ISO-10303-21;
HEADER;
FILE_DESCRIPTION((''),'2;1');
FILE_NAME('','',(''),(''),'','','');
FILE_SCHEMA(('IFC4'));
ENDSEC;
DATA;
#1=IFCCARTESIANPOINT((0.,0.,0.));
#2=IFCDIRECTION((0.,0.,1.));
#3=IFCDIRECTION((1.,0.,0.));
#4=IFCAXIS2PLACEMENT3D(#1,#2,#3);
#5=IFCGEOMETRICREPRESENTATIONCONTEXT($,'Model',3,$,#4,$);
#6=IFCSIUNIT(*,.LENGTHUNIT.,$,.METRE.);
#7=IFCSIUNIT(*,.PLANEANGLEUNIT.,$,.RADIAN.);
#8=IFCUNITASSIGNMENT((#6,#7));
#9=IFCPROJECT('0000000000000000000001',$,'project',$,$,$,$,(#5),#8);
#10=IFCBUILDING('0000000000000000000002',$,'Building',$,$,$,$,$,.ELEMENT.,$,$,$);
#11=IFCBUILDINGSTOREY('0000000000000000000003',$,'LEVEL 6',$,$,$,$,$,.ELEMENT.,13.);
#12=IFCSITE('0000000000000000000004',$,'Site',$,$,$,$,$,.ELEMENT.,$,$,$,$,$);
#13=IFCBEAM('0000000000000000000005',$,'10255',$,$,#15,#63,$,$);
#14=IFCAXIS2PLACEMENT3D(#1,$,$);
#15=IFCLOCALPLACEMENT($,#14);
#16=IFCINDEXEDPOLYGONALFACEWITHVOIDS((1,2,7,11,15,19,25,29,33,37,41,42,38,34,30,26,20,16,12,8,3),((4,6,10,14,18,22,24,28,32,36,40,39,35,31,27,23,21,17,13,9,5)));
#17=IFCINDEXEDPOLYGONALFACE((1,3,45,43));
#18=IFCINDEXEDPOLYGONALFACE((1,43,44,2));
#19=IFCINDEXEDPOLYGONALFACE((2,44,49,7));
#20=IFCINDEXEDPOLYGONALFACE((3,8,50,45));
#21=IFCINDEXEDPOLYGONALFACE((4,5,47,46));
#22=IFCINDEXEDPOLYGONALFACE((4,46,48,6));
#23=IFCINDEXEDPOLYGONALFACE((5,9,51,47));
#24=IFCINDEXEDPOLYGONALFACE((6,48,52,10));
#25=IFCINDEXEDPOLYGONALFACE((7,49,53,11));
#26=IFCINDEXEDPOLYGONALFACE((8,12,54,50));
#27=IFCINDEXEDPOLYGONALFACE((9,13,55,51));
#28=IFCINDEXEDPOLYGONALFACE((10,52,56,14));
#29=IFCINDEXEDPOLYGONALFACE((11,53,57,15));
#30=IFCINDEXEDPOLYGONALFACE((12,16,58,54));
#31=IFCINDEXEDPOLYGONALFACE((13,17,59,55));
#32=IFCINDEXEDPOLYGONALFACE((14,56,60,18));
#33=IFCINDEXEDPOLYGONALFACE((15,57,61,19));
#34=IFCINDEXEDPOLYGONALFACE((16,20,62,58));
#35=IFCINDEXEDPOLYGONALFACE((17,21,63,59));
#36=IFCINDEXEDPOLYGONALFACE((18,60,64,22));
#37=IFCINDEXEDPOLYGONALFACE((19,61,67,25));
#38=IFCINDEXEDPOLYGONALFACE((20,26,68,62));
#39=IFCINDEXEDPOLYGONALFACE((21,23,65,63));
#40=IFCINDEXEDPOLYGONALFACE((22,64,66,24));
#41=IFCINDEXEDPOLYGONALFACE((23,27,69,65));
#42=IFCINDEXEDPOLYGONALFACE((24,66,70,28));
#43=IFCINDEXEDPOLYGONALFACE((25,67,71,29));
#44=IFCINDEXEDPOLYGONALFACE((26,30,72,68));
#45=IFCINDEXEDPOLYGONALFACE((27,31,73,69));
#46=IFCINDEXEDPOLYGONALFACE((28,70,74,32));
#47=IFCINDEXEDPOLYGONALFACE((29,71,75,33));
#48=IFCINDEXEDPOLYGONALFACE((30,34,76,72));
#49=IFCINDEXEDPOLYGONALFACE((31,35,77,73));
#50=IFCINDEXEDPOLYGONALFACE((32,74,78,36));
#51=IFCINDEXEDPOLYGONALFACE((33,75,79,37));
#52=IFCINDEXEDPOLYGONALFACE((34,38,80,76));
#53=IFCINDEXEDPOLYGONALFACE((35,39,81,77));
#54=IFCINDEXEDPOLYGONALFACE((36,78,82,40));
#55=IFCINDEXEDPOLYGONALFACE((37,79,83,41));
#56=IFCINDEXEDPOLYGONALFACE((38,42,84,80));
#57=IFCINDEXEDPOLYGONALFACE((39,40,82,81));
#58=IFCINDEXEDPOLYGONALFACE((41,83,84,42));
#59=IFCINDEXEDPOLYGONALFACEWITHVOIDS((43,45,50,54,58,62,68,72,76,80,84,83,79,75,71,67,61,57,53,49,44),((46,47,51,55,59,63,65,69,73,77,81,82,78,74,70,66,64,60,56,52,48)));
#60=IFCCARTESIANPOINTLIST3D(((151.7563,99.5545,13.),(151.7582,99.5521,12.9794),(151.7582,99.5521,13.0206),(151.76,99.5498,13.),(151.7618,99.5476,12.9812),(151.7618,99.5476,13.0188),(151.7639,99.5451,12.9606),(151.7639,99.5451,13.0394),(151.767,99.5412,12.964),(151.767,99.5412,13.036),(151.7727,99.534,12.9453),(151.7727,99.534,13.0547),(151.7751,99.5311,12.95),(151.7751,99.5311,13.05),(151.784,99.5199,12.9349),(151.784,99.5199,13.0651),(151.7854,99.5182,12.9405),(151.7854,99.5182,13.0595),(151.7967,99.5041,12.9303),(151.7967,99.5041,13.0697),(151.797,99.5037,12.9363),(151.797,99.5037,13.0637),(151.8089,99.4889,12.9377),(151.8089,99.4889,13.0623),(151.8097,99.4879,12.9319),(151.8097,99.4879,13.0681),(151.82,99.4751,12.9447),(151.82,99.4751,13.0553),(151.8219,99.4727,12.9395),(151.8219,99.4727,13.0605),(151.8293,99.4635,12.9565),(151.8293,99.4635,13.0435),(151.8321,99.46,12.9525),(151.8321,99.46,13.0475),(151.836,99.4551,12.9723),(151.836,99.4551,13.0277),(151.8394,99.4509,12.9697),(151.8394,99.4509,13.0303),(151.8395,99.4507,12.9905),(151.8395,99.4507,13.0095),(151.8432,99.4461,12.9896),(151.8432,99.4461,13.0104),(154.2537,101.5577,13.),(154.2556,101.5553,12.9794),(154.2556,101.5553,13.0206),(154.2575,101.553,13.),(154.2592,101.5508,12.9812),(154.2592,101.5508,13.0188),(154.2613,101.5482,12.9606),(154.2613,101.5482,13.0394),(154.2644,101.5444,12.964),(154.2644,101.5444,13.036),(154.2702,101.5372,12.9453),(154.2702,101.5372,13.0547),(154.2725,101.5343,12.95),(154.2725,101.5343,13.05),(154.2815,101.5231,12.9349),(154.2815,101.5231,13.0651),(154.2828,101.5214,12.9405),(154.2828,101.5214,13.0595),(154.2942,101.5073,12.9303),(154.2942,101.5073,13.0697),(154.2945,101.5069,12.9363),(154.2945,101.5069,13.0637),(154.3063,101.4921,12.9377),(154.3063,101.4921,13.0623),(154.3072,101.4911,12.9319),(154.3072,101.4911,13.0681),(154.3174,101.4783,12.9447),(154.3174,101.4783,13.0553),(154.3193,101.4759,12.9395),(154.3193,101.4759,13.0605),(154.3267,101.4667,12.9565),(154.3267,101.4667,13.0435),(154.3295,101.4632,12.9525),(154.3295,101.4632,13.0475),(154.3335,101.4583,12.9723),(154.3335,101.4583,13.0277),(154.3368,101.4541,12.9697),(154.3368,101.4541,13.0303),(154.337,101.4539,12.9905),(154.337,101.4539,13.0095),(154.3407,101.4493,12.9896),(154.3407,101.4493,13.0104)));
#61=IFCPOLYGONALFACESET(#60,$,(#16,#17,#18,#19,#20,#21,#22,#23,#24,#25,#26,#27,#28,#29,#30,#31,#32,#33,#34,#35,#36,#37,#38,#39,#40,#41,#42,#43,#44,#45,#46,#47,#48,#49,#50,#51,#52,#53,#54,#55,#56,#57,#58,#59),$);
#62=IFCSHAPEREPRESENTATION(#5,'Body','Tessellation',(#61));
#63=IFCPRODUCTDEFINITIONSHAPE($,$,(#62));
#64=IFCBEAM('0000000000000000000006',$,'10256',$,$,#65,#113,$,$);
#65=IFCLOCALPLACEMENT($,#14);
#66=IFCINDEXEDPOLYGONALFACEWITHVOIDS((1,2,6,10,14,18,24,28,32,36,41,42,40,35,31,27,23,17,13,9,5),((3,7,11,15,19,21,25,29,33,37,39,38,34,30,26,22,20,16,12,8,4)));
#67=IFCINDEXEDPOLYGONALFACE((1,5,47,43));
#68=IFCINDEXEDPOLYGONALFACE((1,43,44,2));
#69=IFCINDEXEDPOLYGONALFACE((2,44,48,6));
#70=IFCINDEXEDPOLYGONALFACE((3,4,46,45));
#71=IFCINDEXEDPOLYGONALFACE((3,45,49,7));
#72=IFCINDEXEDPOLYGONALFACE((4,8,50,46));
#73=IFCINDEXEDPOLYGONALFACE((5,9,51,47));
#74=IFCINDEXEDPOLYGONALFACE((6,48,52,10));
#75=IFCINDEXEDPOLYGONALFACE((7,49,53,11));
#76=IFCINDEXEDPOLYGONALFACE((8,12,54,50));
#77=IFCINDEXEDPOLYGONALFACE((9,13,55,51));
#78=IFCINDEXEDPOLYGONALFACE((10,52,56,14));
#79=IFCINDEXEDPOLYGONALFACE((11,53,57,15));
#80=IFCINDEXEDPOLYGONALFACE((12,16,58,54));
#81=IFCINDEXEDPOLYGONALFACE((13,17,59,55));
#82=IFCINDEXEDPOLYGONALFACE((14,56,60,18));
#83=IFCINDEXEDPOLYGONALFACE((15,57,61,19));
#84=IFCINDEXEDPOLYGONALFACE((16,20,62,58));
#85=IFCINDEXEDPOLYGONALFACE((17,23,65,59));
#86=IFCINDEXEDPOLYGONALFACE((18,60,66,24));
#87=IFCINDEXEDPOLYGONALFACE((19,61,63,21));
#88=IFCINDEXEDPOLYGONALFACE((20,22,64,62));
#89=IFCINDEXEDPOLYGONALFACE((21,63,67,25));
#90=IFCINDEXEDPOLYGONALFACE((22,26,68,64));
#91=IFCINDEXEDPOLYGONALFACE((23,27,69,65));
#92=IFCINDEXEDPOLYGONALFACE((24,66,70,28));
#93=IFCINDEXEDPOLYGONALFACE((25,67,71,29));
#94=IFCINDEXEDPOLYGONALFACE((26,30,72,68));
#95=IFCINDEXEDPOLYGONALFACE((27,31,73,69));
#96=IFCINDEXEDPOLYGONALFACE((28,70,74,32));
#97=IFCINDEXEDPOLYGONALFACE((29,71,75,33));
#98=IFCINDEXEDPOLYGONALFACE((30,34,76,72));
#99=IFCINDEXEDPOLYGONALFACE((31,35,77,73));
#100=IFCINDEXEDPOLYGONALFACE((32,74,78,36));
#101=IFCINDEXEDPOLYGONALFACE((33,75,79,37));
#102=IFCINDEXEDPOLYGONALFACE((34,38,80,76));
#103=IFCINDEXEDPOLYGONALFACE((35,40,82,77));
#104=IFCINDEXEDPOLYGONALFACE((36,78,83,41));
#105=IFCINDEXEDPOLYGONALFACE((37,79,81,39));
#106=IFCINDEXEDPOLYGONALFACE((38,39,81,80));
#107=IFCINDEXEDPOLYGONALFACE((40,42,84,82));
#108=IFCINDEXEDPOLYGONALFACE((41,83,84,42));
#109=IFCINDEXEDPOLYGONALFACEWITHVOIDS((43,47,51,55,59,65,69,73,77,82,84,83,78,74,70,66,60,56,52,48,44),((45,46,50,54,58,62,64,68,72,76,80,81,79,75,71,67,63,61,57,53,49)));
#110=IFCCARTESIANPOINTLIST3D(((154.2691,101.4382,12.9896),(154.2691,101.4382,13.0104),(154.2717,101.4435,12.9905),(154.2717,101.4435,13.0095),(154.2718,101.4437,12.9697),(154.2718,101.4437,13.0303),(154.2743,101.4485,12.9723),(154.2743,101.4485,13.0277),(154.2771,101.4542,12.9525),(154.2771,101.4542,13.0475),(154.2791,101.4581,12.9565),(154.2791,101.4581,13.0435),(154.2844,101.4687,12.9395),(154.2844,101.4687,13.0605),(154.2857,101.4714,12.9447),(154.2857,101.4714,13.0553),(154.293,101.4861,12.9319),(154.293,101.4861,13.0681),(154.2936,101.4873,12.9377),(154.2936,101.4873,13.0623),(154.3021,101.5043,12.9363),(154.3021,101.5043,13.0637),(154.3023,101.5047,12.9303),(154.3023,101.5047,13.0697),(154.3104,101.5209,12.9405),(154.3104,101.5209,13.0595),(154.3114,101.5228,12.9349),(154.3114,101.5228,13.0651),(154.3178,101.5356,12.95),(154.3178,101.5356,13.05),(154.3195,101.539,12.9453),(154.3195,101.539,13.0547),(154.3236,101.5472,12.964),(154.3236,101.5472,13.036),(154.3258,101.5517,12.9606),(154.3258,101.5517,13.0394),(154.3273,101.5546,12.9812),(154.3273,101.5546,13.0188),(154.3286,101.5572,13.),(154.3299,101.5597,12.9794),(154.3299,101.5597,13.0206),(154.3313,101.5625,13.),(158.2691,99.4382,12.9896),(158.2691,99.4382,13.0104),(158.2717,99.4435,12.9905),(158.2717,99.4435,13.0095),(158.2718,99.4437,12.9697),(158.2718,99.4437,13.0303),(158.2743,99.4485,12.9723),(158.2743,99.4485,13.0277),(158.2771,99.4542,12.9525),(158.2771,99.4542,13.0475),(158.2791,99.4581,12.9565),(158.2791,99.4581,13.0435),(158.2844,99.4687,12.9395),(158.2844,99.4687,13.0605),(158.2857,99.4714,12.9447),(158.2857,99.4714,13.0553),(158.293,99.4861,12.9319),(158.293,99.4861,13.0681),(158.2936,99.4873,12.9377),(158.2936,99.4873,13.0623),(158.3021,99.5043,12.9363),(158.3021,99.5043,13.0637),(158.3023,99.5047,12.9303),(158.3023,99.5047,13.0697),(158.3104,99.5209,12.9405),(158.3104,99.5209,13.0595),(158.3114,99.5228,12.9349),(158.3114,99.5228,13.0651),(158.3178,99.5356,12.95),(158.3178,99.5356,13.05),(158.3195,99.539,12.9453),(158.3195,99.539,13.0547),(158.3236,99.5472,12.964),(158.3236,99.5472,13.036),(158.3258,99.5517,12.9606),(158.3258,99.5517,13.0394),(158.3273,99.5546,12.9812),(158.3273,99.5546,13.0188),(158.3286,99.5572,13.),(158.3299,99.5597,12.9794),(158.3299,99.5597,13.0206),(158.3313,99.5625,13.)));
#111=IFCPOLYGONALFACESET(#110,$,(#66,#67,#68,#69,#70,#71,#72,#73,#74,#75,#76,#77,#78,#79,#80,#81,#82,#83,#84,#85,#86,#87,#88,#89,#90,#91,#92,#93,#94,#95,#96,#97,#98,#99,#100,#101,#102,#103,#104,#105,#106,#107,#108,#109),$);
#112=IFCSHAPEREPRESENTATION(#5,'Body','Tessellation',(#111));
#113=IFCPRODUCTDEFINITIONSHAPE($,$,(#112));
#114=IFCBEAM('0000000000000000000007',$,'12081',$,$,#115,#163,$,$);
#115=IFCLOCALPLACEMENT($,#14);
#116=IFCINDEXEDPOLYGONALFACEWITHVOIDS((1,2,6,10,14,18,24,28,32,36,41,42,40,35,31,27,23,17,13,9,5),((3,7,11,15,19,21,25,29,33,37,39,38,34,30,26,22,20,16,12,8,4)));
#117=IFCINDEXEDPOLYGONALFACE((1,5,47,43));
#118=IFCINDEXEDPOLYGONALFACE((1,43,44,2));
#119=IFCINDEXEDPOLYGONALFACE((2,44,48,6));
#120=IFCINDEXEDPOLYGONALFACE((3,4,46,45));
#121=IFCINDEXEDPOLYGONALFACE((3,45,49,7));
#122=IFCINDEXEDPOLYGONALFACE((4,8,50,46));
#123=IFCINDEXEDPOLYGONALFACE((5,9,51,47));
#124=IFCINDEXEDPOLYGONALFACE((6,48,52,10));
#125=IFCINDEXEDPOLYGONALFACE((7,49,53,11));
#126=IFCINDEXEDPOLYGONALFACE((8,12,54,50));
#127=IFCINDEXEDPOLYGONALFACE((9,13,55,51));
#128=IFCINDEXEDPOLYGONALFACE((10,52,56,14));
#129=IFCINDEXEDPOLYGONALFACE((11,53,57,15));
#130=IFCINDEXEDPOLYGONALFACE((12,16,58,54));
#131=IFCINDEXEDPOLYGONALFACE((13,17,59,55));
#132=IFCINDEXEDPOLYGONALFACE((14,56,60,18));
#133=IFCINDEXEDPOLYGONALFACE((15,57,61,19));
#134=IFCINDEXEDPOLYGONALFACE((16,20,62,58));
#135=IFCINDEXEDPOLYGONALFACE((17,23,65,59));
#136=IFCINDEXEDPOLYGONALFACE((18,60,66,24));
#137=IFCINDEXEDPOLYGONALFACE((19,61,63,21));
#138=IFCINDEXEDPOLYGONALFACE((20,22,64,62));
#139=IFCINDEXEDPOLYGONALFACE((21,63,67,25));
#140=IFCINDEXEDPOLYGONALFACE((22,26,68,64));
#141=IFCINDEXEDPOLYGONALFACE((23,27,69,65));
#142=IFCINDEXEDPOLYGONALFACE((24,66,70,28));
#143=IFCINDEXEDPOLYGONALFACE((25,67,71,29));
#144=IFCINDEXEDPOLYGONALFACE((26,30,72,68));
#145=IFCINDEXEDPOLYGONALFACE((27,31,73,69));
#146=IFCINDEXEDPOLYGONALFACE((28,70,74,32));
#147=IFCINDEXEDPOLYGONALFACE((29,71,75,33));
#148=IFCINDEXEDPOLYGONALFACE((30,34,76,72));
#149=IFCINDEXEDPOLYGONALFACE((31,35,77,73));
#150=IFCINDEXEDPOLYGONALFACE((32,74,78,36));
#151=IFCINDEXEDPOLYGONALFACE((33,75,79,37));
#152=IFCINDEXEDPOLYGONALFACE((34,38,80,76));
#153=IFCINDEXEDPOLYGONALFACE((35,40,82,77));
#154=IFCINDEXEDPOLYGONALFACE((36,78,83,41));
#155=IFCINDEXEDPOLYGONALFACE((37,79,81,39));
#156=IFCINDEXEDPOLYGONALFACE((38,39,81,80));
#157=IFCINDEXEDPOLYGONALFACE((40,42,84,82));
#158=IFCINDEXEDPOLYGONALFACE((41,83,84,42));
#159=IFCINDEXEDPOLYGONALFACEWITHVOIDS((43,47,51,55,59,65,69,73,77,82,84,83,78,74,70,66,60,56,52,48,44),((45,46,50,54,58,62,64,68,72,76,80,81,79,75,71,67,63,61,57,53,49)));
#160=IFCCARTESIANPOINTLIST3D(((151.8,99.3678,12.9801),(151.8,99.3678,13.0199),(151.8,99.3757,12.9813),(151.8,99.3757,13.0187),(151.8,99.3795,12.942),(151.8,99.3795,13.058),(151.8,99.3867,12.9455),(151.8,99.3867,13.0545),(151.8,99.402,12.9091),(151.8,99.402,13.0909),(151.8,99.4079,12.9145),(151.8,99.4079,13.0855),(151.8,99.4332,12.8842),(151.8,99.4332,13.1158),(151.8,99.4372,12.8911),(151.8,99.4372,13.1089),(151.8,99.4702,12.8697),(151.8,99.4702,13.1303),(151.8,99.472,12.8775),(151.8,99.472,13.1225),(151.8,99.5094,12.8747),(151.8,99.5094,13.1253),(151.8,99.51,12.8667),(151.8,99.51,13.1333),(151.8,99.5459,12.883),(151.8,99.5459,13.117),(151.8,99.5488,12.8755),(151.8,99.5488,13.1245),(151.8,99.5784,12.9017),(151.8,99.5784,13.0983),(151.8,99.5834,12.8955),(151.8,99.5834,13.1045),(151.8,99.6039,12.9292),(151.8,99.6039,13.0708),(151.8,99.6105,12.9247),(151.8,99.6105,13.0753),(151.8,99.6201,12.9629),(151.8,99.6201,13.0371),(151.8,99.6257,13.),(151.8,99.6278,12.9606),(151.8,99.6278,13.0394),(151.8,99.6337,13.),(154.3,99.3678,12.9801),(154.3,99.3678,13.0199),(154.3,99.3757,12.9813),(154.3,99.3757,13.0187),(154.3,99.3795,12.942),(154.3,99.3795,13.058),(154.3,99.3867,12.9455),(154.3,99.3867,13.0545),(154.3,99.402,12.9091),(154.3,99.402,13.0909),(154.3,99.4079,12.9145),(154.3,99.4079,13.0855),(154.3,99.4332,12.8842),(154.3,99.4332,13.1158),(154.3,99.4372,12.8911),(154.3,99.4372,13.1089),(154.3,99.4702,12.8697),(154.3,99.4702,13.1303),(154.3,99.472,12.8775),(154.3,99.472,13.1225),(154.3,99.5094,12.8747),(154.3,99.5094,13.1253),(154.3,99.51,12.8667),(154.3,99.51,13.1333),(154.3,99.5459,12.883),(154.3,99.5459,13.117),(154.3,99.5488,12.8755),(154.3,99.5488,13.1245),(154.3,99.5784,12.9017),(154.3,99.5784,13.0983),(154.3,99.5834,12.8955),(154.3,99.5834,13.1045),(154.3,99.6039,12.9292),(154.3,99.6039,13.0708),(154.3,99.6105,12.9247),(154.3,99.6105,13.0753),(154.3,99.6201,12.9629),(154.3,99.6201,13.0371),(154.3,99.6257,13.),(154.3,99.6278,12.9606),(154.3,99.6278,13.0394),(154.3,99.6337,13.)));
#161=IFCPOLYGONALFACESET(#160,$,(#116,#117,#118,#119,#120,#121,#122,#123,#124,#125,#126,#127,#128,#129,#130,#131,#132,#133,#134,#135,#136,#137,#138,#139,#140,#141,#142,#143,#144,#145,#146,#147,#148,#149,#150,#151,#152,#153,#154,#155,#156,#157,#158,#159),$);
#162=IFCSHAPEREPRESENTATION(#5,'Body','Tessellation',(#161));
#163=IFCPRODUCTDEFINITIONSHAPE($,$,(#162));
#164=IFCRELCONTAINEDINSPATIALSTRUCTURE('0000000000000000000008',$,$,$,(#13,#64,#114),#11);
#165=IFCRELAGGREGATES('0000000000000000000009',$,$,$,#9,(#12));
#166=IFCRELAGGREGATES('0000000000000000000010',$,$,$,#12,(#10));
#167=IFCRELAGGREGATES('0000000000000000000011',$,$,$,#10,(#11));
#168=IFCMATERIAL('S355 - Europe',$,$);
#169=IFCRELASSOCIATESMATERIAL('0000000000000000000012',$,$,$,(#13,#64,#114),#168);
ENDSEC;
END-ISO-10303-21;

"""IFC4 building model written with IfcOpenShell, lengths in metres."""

from ifc_helpers import new_model, si_unit, frame, origin_with_axes, origin_2d_with_axis, place, context, project, spatial, hollow_circle, extrude, material, material_profile, profile_set, profile_usage, element, save


model = new_model("IFC4")

# Units and contexts
model_context = context("Model", 3, world=origin_with_axes())
ifc_project = project(units=[si_unit("LENGTHUNIT", "METRE"), si_unit("PLANEANGLEUNIT", "RADIAN")], contexts=[model_context])

# Site, building, storey
site = spatial("IfcSite", under=ifc_project, Name="Site", CompositionType="ELEMENT")
building = spatial("IfcBuilding", under=site, Name="Building", CompositionType="ELEMENT")
storey = spatial("IfcBuildingStorey", under=building, Name="LEVEL 6", CompositionType="ELEMENT", Elevation=13.0)

# Shared definitions
ifc_material = material(Name="S355 - Europe")

# Beams
ifc_material_profile_1 = material_profile(ifc_material, hollow_circle(Radius=0.0699, WallThickness=0.006, at=origin_2d_with_axis()))
ifc_profile_set_1 = profile_set([ifc_material_profile_1])
ifc_profile_usage_1 = profile_usage(ifc_profile_set_1, cardinal=10)
beam_1_placement = place(None, frame((151.8, 99.5, 13.0), z_axis=(0.780069, 0.625693, 0.0), x_axis=(-0.624695, 0.780869, 0.0)))
element("IfcBeam", 1, at=beam_1_placement, inside=storey, material=ifc_profile_usage_1, Name="10255", context=model_context, shape_type="SweptSolid", body=[
    extrude(hollow_circle(Radius=0.0699, WallThickness=0.006, at=origin_2d_with_axis()), origin_with_axes(), (0.0, 0.0, 1.0), 3.2016),
])
ifc_material_profile_2 = material_profile(ifc_material, hollow_circle(Radius=0.0699, WallThickness=0.006, at=origin_2d_with_axis()))
ifc_profile_set_2 = profile_set([ifc_material_profile_2])
ifc_profile_usage_2 = profile_usage(ifc_profile_set_2, cardinal=10)
beam_2_placement = place(None, frame((154.3, 101.5, 13.0), z_axis=(0.894427, -0.447214, 0.0), x_axis=(0.447214, 0.894427, 0.0)))
element("IfcBeam", 2, at=beam_2_placement, inside=storey, material=ifc_profile_usage_2, Name="10256", context=model_context, shape_type="SweptSolid", body=[
    extrude(hollow_circle(Radius=0.0699, WallThickness=0.006, at=origin_2d_with_axis()), origin_with_axes(), (0.0, 0.0, 1.0), 4.4721),
])
ifc_material_profile_3 = material_profile(ifc_material, hollow_circle(Radius=0.1337, WallThickness=0.008, at=origin_2d_with_axis()))
ifc_profile_set_3 = profile_set([ifc_material_profile_3])
ifc_profile_usage_3 = profile_usage(ifc_profile_set_3, cardinal=10)
beam_3_placement = place(None, frame((151.8, 99.5, 13.0), z_axis=(1.0, 0.0, 0.0), x_axis=(0.0, 1.0, 0.0)))
element("IfcBeam", 3, at=beam_3_placement, inside=storey, material=ifc_profile_usage_3, Name="12081", context=model_context, shape_type="SweptSolid", body=[
    extrude(hollow_circle(Radius=0.1337, WallThickness=0.008, at=origin_2d_with_axis()), origin_with_axes(), (0.0, 0.0, 1.0), 2.5),
])

save(model, "model.ifc")
